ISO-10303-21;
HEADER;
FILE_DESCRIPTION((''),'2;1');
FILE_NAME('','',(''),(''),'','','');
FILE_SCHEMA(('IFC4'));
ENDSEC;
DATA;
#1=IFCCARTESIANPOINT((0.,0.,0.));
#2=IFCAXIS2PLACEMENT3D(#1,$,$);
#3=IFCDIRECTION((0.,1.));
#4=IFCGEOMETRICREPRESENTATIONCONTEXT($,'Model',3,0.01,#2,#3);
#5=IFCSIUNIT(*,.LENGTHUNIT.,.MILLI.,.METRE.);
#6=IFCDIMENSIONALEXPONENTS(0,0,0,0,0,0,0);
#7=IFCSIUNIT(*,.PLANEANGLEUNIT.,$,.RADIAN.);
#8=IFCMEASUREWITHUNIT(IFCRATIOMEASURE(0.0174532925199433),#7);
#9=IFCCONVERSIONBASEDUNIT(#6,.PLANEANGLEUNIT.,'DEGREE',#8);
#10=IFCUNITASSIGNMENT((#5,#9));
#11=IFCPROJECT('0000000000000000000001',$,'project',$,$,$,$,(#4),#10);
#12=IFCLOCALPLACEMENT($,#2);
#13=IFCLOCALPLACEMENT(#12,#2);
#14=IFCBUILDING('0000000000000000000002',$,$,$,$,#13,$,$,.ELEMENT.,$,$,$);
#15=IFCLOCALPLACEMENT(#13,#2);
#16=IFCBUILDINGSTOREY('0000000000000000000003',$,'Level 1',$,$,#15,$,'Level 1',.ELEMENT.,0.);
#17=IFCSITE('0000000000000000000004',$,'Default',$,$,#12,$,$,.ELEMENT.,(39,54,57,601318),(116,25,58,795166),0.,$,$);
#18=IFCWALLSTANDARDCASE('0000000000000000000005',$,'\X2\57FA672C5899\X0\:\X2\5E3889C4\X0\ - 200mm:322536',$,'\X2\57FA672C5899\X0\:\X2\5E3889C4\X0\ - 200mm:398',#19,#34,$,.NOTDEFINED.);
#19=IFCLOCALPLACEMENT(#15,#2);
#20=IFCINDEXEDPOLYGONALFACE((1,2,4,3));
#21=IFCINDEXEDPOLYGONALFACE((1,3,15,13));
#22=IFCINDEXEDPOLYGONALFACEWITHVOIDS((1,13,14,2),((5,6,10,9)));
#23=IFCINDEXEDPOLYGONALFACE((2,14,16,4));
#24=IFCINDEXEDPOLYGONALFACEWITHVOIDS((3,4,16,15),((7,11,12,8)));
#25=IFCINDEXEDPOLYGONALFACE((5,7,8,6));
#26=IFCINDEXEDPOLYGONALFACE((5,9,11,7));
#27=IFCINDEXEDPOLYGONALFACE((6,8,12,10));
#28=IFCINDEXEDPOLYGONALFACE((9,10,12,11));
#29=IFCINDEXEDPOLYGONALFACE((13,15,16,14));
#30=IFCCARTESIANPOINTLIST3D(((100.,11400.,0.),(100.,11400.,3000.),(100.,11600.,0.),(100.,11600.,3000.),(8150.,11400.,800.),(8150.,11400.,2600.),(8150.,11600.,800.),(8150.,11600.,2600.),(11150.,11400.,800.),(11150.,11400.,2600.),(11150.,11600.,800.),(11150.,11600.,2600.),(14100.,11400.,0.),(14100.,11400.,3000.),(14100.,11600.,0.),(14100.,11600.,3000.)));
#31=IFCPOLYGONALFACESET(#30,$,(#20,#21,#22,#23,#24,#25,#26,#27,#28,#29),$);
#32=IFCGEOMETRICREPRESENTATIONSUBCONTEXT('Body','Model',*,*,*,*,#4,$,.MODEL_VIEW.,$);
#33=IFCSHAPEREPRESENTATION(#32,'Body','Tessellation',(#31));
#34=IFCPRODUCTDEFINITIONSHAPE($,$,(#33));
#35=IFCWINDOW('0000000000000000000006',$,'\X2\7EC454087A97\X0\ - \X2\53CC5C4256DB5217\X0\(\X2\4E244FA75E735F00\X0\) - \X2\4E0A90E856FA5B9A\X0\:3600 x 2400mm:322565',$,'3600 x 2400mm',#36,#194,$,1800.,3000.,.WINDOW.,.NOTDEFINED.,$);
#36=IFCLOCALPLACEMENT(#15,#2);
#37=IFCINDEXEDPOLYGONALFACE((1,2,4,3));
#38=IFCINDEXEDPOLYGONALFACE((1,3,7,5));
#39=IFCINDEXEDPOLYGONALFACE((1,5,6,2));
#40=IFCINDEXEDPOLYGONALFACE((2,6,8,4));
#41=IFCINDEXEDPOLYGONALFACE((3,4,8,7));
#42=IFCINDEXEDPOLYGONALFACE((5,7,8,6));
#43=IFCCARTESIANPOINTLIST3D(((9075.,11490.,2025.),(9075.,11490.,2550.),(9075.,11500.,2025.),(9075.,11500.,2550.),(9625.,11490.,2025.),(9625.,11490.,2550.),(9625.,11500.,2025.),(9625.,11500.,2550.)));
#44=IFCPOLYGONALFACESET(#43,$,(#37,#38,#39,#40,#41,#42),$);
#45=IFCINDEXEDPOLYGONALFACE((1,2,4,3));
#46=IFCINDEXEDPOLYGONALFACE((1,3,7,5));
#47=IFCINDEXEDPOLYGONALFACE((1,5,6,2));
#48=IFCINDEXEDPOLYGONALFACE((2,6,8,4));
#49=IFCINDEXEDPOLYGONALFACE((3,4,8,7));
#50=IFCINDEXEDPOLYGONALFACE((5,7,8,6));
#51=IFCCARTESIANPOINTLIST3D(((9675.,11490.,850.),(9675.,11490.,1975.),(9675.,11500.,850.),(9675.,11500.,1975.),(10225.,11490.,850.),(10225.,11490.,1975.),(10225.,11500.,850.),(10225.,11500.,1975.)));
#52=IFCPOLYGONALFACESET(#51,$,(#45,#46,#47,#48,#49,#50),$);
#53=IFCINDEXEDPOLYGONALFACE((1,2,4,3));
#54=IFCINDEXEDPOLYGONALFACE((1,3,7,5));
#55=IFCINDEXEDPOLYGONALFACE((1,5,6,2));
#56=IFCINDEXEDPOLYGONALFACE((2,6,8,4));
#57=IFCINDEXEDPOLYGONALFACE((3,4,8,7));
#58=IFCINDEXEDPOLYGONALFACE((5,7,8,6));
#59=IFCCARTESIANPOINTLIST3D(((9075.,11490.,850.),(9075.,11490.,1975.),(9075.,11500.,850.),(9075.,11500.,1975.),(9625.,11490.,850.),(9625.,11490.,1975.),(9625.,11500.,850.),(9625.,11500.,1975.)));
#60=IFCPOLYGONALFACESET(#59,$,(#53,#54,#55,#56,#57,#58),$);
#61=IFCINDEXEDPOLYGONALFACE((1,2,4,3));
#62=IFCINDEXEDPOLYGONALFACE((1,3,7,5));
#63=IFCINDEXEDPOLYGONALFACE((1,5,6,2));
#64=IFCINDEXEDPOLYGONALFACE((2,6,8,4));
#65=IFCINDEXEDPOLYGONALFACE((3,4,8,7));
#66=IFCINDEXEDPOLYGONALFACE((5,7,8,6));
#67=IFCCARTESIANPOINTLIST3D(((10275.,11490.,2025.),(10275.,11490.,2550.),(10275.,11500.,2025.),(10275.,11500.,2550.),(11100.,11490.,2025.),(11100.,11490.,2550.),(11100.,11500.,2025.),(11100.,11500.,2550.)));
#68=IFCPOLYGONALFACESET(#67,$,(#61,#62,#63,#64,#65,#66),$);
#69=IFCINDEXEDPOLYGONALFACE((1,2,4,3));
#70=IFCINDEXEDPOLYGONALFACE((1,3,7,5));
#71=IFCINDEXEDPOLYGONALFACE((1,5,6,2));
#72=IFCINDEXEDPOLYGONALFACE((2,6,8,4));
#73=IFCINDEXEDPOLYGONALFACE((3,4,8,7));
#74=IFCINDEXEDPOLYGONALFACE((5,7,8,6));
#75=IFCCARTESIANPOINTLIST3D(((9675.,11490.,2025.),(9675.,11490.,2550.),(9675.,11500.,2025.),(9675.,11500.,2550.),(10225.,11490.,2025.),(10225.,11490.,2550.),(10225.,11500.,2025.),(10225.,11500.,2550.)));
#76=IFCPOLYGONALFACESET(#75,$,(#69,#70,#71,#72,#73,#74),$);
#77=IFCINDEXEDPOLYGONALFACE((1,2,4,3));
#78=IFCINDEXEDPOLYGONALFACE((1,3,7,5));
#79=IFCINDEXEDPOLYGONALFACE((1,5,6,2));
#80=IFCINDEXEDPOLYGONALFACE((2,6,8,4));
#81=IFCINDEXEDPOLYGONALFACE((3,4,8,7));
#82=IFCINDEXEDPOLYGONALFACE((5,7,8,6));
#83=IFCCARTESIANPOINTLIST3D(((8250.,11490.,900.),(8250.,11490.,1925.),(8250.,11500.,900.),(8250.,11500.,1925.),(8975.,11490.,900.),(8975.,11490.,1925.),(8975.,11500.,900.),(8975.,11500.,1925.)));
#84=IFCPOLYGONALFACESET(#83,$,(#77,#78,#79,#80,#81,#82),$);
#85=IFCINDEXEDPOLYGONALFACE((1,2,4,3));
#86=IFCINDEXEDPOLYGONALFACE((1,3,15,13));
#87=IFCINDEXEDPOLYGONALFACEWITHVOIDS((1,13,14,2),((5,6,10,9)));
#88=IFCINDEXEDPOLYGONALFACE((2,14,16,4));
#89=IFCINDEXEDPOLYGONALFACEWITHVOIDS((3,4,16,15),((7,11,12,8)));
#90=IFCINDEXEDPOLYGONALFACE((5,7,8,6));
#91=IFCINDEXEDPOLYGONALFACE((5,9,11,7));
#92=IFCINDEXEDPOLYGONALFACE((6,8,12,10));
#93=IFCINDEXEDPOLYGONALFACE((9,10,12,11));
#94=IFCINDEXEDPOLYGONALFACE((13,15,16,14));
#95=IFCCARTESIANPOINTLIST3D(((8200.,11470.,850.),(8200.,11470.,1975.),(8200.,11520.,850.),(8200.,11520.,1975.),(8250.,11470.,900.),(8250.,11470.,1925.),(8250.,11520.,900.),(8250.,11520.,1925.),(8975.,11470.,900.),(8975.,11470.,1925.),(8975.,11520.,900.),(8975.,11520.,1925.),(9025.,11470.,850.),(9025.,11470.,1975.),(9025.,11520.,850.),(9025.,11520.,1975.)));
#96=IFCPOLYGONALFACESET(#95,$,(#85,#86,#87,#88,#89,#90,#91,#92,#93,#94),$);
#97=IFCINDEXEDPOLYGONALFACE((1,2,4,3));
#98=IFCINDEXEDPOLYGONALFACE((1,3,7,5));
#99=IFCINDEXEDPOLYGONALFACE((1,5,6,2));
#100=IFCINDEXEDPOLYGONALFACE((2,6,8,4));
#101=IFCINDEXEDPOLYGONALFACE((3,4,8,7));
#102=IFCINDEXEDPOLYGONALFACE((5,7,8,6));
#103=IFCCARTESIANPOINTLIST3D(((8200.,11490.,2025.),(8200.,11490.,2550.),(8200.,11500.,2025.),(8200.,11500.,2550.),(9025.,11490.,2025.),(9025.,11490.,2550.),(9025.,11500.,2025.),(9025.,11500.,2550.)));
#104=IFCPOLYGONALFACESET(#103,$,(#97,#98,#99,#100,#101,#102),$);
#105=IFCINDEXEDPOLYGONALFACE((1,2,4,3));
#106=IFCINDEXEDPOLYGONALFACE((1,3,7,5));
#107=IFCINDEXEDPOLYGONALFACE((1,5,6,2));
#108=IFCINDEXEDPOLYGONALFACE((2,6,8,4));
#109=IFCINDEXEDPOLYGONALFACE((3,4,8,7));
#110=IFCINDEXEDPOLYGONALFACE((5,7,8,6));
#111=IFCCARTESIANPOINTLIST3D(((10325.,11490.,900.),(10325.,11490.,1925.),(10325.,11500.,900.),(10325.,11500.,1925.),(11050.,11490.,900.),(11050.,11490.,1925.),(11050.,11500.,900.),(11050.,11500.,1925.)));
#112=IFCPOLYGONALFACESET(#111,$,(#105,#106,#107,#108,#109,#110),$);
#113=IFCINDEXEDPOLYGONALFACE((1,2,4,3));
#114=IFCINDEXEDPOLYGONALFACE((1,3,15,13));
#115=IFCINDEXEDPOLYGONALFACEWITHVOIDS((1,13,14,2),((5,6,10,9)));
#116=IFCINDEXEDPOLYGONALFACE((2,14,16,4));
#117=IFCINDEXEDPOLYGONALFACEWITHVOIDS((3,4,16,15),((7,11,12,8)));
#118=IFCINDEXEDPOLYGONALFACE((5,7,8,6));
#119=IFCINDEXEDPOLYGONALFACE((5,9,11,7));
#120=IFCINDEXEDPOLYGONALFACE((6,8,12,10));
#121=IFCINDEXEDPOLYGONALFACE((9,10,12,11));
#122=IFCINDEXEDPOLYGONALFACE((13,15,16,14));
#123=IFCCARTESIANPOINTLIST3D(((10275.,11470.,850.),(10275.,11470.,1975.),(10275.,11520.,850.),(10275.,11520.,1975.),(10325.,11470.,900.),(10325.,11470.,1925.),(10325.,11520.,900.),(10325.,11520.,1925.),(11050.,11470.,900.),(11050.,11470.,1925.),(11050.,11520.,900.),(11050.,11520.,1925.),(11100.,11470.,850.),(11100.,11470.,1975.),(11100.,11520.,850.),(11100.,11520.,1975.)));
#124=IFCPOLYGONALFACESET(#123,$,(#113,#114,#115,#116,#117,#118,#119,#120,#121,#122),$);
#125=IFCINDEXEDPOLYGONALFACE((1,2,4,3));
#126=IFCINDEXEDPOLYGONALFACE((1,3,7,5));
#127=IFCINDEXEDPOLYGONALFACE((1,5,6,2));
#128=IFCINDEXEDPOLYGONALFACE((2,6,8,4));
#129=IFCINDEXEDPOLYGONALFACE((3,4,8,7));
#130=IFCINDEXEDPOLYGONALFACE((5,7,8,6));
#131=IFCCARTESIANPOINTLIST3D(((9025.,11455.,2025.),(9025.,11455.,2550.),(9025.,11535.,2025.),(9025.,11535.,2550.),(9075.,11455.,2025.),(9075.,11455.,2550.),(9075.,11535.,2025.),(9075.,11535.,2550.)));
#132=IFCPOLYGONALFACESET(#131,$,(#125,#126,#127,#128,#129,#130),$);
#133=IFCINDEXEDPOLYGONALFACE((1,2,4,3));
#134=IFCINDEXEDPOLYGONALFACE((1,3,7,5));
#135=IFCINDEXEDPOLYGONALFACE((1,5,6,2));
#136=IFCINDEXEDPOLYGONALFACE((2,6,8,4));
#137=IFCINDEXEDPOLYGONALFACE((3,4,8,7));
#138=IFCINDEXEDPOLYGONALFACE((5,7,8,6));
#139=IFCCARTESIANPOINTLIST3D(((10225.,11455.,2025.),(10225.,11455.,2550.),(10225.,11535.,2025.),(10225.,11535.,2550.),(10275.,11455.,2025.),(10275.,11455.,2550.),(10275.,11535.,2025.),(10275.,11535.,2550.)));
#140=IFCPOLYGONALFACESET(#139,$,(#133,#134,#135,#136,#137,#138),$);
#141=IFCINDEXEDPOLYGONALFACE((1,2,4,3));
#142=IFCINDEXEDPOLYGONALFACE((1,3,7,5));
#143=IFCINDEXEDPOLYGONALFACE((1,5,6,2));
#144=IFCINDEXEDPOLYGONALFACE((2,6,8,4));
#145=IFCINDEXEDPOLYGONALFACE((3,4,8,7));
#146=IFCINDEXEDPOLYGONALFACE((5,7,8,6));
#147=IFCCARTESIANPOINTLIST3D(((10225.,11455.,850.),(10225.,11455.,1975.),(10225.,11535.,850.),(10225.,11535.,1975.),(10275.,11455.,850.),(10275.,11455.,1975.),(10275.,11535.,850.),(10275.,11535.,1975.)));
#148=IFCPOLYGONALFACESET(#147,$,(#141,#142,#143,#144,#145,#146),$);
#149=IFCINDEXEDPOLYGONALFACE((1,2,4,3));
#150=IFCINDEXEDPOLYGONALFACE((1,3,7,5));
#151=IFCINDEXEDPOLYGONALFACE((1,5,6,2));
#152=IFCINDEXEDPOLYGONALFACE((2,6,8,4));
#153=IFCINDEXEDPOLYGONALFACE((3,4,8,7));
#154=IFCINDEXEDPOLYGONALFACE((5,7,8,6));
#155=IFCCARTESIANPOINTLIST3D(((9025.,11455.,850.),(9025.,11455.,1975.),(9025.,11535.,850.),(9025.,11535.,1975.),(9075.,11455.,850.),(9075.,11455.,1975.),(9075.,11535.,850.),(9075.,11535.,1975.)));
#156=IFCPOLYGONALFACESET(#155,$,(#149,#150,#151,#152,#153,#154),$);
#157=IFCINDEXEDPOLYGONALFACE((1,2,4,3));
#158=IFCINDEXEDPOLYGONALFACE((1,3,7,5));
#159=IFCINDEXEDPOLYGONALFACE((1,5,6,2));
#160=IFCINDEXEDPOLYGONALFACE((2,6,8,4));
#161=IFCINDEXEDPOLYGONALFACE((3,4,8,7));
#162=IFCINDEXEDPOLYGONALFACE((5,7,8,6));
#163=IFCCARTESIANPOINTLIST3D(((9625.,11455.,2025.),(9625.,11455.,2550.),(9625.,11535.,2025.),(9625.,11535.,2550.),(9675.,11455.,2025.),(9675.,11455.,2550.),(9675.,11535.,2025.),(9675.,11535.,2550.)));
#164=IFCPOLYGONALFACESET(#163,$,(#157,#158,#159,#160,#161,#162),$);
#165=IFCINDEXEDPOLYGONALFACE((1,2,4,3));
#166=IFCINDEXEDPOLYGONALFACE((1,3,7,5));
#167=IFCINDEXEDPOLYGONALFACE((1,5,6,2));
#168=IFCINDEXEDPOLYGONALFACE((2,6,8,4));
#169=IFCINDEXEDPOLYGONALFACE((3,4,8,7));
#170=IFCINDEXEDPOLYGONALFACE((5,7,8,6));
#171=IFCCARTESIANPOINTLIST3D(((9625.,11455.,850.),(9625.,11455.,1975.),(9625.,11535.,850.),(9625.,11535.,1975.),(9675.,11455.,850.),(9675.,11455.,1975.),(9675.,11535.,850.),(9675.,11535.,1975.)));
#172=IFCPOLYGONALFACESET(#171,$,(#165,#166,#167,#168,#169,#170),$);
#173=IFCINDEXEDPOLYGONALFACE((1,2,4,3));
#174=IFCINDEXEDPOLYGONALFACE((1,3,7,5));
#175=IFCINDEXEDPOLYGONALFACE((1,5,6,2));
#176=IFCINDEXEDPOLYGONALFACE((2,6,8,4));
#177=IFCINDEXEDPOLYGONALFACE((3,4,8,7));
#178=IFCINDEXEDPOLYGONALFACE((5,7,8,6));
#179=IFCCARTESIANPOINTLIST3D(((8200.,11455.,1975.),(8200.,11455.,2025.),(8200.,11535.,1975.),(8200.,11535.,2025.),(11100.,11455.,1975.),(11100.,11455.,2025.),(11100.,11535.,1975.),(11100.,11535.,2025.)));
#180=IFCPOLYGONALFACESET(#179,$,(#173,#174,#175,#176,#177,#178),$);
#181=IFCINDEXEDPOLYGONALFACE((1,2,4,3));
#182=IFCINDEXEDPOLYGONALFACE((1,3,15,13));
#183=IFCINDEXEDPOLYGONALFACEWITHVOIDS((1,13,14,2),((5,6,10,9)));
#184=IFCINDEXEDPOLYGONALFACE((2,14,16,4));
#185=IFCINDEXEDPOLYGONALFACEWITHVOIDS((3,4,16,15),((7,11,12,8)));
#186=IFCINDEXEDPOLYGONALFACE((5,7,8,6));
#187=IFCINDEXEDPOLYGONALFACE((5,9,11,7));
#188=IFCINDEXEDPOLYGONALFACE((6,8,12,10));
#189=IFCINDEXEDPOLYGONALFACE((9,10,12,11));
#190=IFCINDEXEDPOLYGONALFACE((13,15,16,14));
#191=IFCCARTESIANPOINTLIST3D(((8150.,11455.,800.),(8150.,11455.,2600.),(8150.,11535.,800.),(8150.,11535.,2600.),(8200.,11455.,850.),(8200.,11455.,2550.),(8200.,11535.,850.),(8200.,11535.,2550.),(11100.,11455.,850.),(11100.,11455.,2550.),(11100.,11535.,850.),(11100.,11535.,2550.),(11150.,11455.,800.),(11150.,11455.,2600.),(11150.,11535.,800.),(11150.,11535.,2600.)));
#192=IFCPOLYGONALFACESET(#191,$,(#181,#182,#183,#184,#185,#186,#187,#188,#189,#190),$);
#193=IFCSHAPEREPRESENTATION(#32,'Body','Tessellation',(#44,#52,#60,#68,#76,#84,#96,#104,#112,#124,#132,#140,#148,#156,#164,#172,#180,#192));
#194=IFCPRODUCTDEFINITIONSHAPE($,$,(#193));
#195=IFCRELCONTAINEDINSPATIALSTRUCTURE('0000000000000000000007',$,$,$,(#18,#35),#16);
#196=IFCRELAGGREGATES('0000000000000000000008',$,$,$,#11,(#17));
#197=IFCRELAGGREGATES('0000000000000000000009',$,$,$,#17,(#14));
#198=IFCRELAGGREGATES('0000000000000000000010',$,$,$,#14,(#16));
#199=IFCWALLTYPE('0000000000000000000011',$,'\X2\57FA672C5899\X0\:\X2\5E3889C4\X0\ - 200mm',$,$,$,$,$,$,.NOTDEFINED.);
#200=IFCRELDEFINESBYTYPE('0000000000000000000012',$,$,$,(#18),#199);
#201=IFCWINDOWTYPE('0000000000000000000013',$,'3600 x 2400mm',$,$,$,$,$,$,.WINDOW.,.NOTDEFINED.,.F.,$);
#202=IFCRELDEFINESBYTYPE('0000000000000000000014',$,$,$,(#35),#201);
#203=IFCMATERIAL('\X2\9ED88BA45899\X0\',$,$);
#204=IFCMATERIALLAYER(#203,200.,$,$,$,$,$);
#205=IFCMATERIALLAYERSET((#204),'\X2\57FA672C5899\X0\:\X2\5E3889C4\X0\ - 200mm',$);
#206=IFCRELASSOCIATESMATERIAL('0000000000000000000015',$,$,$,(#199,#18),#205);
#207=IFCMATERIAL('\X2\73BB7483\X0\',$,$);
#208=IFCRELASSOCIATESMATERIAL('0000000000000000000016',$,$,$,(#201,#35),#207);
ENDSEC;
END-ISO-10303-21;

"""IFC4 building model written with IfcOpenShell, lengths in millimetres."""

from ifc_helpers import new_model, entity, si_unit, converted_unit, direction, frame, frame_2d, origin, origin_2d_with_axis, place, context, subcontext, project, spatial, polyline, rectangle, outline, extrude, source, transform, mapped, material, layer, layer_set, layer_usage, type_object, type_shapes, element, fill, save


model = new_model("IFC4")

# Units and contexts
model_context = context("Model", 3, precision=0.01, world=origin(), true_north=direction((0.0, 1.0)))
body_context = subcontext(model_context, "Body", "Model", "MODEL_VIEW")
ifc_project = project(units=[si_unit("LENGTHUNIT", "METRE", prefix="MILLI"), converted_unit("PLANEANGLEUNIT", "DEGREE", entity("IfcRatioMeasure", 0.0174532925199433), si_unit("PLANEANGLEUNIT", "RADIAN"), dimensions=[0, 0, 0, 0, 0, 0, 0])], contexts=[model_context])

# Site, building, storey
site_placement = place(None, origin())
site = spatial("IfcSite", under=ifc_project, at=site_placement, Name="Default", CompositionType="ELEMENT", RefLatitude=(39, 54, 57, 601318), RefLongitude=(116, 25, 58, 795166), RefElevation=0.0)
building_placement = place(site_placement, origin())
building = spatial("IfcBuilding", under=site, at=building_placement, CompositionType="ELEMENT")
storey_placement = place(building_placement, origin())
storey = spatial("IfcBuildingStorey", under=building, at=storey_placement, Name="Level 1", LongName="Level 1", CompositionType="ELEMENT", Elevation=0.0)

# Shared definitions
ifc_material_1 = material(Name="默认墙")
ifc_layer_1 = layer(ifc_material_1, 200.0)
ifc_layer_set_1 = layer_set([ifc_layer_1], Name="基本墙:常规 - 200mm")
wall_type = type_object("IfcWallType", Name="基本墙:常规 - 200mm", PredefinedType="NOTDEFINED", material=ifc_layer_set_1)
ifc_material_2 = material(Name="玻璃")
window_type_1 = type_object("IfcWindowType", Name="3600 x 2400mm", ParameterTakesPrecedence=False, PartitioningType="NOTDEFINED", PredefinedType="WINDOW", material=ifc_material_2)
shared_shape_1 = source(origin(), body_context, "Body", "SweptSolid", [
    extrude(rectangle(XDim=10.0, YDim=550.0, at=origin_2d_with_axis()), frame((1200.0, 95.0, 1225.0), z_axis=(0.0, 0.0, 1.0), x_axis=(0.0, 1.0, 0.0)), (0.0, 0.0, 1.0), 525.0),
    extrude(rectangle(XDim=10.0, YDim=550.0, at=origin_2d_with_axis()), frame((1800.0, 95.0, 50.0), z_axis=(0.0, 0.0, 1.0), x_axis=(0.0, 1.0, 0.0)), (0.0, 0.0, 1.0), 1125.0),
    extrude(rectangle(XDim=10.0, YDim=550.0, at=origin_2d_with_axis()), frame((1200.0, 95.0, 50.0), z_axis=(0.0, 0.0, 1.0), x_axis=(0.0, 1.0, 0.0)), (0.0, 0.0, 1.0), 1125.0),
    extrude(rectangle(XDim=10.0, YDim=825.0, at=origin_2d_with_axis()), frame((2537.5, 95.0, 1225.0), z_axis=(0.0, 0.0, 1.0), x_axis=(0.0, 1.0, 0.0)), (0.0, 0.0, 1.0), 525.0),
    extrude(rectangle(XDim=10.0, YDim=550.0, at=origin_2d_with_axis()), frame((1800.0, 95.0, 1225.0), z_axis=(0.0, 0.0, 1.0), x_axis=(0.0, 1.0, 0.0)), (0.0, 0.0, 1.0), 525.0),
    extrude(rectangle(XDim=10.0, YDim=725.0, at=origin_2d_with_axis()), frame((462.5, 95.0, 100.0), z_axis=(0.0, 0.0, 1.0), x_axis=(0.0, 1.0, 0.0)), (0.0, 0.0, 1.0), 1025.0),
    extrude(outline(polyline([(-562.5, -412.5), (562.5, -412.5), (562.5, 412.5), (-562.5, 412.5), (-562.5, -412.5)]), holes=[polyline([(512.5, -362.5), (-512.5, -362.5), (-512.5, 362.5), (512.5, 362.5), (512.5, -362.5)])]), frame((462.5, 70.0, 612.5), z_axis=(0.0, 1.0, 0.0), x_axis=(0.0, 0.0, -1.0)), (0.0, 0.0, 1.0), 50.0),
    extrude(rectangle(XDim=10.0, YDim=825.0, at=origin_2d_with_axis()), frame((462.5, 95.0, 1225.0), z_axis=(0.0, 0.0, 1.0), x_axis=(0.0, 1.0, 0.0)), (0.0, 0.0, 1.0), 525.0),
    extrude(rectangle(XDim=10.0, YDim=725.0, at=origin_2d_with_axis()), frame((2537.5, 95.0, 100.0), z_axis=(0.0, 0.0, 1.0), x_axis=(0.0, 1.0, 0.0)), (0.0, 0.0, 1.0), 1025.0),
    extrude(outline(polyline([(-562.5, -412.5), (562.5, -412.5), (562.5, 412.5), (-562.5, 412.5), (-562.5, -412.5)]), holes=[polyline([(512.5, -362.5), (-512.5, -362.5), (-512.5, 362.5), (512.5, 362.5), (512.5, -362.5)])]), frame((2537.5, 70.0, 612.5), z_axis=(0.0, 1.0, 0.0), x_axis=(0.0, 0.0, -1.0)), (0.0, 0.0, 1.0), 50.0),
    extrude(rectangle(XDim=80.0, YDim=50.0, at=origin_2d_with_axis()), frame((900.0, 95.0, 1225.0), z_axis=(0.0, 0.0, 1.0), x_axis=(0.0, -1.0, 0.0)), (0.0, 0.0, 1.0), 525.0),
    extrude(rectangle(XDim=80.0, YDim=50.0, at=origin_2d_with_axis()), frame((2100.0, 95.0, 1225.0), z_axis=(0.0, 0.0, 1.0), x_axis=(0.0, -1.0, 0.0)), (0.0, 0.0, 1.0), 525.0),
    extrude(rectangle(XDim=80.0, YDim=50.0, at=origin_2d_with_axis()), frame((2100.0, 95.0, 50.0), z_axis=(0.0, 0.0, 1.0), x_axis=(0.0, -1.0, 0.0)), (0.0, 0.0, 1.0), 1125.0),
    extrude(rectangle(XDim=80.0, YDim=50.0, at=origin_2d_with_axis()), frame((900.0, 95.0, 50.0), z_axis=(0.0, 0.0, 1.0), x_axis=(0.0, -1.0, 0.0)), (0.0, 0.0, 1.0), 1125.0),
    extrude(rectangle(XDim=80.0, YDim=50.0, at=origin_2d_with_axis()), frame((1500.0, 95.0, 1225.0), z_axis=(0.0, 0.0, 1.0), x_axis=(0.0, -1.0, 0.0)), (0.0, 0.0, 1.0), 525.0),
    extrude(rectangle(XDim=80.0, YDim=50.0, at=origin_2d_with_axis()), frame((1500.0, 95.0, 50.0), z_axis=(0.0, 0.0, 1.0), x_axis=(0.0, -1.0, 0.0)), (0.0, 0.0, 1.0), 1125.0),
    extrude(rectangle(XDim=80.0, YDim=2900.0, at=origin_2d_with_axis()), frame((1500.0, 95.0, 1175.0), z_axis=(0.0, 0.0, 1.0), x_axis=(0.0, -1.0, 0.0)), (0.0, 0.0, 1.0), 50.0),
    extrude(outline(polyline([(-1500.0, -900.0), (1500.0, -900.0), (1500.0, 900.0), (-1500.0, 900.0), (-1500.0, -900.0)]), holes=[polyline([(1450.0, -850.0), (-1450.0, -850.0), (-1450.0, 850.0), (1450.0, 850.0), (1450.0, -850.0)])]), frame((1500.0, 55.0, 900.0), z_axis=(0.0, 1.0, 0.0), x_axis=(1.0, 0.0, 0.0)), (0.0, 0.0, 1.0), 80.0),
])
type_shapes(window_type_1, [shared_shape_1])

# Wall, opening, window
ifc_layer_usage_1 = layer_usage(ifc_layer_set_1, "AXIS2", "NEGATIVE", 100.0)
wall_1_placement = place(storey_placement, frame((100.0, 11500.0, 0.0)))
wall_1 = element("IfcWallStandardCase", 1, at=wall_1_placement, inside=storey, type_object=wall_type, material=ifc_layer_usage_1, Name="基本墙:常规 - 200mm:322536", ObjectType="基本墙:常规 - 200mm:398", PredefinedType="NOTDEFINED", context=body_context, shape_type="SweptSolid", body=[
    extrude(rectangle(XDim=14000.0, YDim=200.0, at=frame_2d((7000.0, 0.0), x_axis=(-1.0, 0.0))), origin(), (0.0, 0.0, 1.0), 3000.0),
])
opening_1_placement = place(wall_1_placement, frame((8050.0, -100.0, 800.0)))
opening_1 = element("IfcOpeningElement", 2, at=opening_1_placement, cuts=wall_1, ObjectType="Opening", PredefinedType="OPENING", context=body_context, shape_type="SweptSolid", body=[
    extrude(rectangle(XDim=1800.0, YDim=3000.0, at=frame_2d((900.0, 1500.0), x_axis=(1.0, 0.0))), frame((0.0, 0.0, 0.0), z_axis=(0.0, 1.0, 0.0), x_axis=(0.0, 0.0, 1.0)), (0.0, 0.0, 1.0), 200.0),
])
window_1_placement = place(opening_1_placement, origin())
window_1 = element("IfcWindow", 3, at=window_1_placement, inside=storey, type_object=window_type_1, material=ifc_material_2, Name="组合窗 - 双层四列(两侧平开) - 上部固定:3600 x 2400mm:322565", ObjectType="3600 x 2400mm", OverallHeight=1800.0, OverallWidth=3000.0, PartitioningType="NOTDEFINED", PredefinedType="WINDOW", context=body_context, shape_type="MappedRepresentation", body=[
    mapped(shared_shape_1, transform((0.0, 0.0, 0.0), scale=1.0)),
])
fill(opening_1, window_1)

save(model, "model.ifc")
